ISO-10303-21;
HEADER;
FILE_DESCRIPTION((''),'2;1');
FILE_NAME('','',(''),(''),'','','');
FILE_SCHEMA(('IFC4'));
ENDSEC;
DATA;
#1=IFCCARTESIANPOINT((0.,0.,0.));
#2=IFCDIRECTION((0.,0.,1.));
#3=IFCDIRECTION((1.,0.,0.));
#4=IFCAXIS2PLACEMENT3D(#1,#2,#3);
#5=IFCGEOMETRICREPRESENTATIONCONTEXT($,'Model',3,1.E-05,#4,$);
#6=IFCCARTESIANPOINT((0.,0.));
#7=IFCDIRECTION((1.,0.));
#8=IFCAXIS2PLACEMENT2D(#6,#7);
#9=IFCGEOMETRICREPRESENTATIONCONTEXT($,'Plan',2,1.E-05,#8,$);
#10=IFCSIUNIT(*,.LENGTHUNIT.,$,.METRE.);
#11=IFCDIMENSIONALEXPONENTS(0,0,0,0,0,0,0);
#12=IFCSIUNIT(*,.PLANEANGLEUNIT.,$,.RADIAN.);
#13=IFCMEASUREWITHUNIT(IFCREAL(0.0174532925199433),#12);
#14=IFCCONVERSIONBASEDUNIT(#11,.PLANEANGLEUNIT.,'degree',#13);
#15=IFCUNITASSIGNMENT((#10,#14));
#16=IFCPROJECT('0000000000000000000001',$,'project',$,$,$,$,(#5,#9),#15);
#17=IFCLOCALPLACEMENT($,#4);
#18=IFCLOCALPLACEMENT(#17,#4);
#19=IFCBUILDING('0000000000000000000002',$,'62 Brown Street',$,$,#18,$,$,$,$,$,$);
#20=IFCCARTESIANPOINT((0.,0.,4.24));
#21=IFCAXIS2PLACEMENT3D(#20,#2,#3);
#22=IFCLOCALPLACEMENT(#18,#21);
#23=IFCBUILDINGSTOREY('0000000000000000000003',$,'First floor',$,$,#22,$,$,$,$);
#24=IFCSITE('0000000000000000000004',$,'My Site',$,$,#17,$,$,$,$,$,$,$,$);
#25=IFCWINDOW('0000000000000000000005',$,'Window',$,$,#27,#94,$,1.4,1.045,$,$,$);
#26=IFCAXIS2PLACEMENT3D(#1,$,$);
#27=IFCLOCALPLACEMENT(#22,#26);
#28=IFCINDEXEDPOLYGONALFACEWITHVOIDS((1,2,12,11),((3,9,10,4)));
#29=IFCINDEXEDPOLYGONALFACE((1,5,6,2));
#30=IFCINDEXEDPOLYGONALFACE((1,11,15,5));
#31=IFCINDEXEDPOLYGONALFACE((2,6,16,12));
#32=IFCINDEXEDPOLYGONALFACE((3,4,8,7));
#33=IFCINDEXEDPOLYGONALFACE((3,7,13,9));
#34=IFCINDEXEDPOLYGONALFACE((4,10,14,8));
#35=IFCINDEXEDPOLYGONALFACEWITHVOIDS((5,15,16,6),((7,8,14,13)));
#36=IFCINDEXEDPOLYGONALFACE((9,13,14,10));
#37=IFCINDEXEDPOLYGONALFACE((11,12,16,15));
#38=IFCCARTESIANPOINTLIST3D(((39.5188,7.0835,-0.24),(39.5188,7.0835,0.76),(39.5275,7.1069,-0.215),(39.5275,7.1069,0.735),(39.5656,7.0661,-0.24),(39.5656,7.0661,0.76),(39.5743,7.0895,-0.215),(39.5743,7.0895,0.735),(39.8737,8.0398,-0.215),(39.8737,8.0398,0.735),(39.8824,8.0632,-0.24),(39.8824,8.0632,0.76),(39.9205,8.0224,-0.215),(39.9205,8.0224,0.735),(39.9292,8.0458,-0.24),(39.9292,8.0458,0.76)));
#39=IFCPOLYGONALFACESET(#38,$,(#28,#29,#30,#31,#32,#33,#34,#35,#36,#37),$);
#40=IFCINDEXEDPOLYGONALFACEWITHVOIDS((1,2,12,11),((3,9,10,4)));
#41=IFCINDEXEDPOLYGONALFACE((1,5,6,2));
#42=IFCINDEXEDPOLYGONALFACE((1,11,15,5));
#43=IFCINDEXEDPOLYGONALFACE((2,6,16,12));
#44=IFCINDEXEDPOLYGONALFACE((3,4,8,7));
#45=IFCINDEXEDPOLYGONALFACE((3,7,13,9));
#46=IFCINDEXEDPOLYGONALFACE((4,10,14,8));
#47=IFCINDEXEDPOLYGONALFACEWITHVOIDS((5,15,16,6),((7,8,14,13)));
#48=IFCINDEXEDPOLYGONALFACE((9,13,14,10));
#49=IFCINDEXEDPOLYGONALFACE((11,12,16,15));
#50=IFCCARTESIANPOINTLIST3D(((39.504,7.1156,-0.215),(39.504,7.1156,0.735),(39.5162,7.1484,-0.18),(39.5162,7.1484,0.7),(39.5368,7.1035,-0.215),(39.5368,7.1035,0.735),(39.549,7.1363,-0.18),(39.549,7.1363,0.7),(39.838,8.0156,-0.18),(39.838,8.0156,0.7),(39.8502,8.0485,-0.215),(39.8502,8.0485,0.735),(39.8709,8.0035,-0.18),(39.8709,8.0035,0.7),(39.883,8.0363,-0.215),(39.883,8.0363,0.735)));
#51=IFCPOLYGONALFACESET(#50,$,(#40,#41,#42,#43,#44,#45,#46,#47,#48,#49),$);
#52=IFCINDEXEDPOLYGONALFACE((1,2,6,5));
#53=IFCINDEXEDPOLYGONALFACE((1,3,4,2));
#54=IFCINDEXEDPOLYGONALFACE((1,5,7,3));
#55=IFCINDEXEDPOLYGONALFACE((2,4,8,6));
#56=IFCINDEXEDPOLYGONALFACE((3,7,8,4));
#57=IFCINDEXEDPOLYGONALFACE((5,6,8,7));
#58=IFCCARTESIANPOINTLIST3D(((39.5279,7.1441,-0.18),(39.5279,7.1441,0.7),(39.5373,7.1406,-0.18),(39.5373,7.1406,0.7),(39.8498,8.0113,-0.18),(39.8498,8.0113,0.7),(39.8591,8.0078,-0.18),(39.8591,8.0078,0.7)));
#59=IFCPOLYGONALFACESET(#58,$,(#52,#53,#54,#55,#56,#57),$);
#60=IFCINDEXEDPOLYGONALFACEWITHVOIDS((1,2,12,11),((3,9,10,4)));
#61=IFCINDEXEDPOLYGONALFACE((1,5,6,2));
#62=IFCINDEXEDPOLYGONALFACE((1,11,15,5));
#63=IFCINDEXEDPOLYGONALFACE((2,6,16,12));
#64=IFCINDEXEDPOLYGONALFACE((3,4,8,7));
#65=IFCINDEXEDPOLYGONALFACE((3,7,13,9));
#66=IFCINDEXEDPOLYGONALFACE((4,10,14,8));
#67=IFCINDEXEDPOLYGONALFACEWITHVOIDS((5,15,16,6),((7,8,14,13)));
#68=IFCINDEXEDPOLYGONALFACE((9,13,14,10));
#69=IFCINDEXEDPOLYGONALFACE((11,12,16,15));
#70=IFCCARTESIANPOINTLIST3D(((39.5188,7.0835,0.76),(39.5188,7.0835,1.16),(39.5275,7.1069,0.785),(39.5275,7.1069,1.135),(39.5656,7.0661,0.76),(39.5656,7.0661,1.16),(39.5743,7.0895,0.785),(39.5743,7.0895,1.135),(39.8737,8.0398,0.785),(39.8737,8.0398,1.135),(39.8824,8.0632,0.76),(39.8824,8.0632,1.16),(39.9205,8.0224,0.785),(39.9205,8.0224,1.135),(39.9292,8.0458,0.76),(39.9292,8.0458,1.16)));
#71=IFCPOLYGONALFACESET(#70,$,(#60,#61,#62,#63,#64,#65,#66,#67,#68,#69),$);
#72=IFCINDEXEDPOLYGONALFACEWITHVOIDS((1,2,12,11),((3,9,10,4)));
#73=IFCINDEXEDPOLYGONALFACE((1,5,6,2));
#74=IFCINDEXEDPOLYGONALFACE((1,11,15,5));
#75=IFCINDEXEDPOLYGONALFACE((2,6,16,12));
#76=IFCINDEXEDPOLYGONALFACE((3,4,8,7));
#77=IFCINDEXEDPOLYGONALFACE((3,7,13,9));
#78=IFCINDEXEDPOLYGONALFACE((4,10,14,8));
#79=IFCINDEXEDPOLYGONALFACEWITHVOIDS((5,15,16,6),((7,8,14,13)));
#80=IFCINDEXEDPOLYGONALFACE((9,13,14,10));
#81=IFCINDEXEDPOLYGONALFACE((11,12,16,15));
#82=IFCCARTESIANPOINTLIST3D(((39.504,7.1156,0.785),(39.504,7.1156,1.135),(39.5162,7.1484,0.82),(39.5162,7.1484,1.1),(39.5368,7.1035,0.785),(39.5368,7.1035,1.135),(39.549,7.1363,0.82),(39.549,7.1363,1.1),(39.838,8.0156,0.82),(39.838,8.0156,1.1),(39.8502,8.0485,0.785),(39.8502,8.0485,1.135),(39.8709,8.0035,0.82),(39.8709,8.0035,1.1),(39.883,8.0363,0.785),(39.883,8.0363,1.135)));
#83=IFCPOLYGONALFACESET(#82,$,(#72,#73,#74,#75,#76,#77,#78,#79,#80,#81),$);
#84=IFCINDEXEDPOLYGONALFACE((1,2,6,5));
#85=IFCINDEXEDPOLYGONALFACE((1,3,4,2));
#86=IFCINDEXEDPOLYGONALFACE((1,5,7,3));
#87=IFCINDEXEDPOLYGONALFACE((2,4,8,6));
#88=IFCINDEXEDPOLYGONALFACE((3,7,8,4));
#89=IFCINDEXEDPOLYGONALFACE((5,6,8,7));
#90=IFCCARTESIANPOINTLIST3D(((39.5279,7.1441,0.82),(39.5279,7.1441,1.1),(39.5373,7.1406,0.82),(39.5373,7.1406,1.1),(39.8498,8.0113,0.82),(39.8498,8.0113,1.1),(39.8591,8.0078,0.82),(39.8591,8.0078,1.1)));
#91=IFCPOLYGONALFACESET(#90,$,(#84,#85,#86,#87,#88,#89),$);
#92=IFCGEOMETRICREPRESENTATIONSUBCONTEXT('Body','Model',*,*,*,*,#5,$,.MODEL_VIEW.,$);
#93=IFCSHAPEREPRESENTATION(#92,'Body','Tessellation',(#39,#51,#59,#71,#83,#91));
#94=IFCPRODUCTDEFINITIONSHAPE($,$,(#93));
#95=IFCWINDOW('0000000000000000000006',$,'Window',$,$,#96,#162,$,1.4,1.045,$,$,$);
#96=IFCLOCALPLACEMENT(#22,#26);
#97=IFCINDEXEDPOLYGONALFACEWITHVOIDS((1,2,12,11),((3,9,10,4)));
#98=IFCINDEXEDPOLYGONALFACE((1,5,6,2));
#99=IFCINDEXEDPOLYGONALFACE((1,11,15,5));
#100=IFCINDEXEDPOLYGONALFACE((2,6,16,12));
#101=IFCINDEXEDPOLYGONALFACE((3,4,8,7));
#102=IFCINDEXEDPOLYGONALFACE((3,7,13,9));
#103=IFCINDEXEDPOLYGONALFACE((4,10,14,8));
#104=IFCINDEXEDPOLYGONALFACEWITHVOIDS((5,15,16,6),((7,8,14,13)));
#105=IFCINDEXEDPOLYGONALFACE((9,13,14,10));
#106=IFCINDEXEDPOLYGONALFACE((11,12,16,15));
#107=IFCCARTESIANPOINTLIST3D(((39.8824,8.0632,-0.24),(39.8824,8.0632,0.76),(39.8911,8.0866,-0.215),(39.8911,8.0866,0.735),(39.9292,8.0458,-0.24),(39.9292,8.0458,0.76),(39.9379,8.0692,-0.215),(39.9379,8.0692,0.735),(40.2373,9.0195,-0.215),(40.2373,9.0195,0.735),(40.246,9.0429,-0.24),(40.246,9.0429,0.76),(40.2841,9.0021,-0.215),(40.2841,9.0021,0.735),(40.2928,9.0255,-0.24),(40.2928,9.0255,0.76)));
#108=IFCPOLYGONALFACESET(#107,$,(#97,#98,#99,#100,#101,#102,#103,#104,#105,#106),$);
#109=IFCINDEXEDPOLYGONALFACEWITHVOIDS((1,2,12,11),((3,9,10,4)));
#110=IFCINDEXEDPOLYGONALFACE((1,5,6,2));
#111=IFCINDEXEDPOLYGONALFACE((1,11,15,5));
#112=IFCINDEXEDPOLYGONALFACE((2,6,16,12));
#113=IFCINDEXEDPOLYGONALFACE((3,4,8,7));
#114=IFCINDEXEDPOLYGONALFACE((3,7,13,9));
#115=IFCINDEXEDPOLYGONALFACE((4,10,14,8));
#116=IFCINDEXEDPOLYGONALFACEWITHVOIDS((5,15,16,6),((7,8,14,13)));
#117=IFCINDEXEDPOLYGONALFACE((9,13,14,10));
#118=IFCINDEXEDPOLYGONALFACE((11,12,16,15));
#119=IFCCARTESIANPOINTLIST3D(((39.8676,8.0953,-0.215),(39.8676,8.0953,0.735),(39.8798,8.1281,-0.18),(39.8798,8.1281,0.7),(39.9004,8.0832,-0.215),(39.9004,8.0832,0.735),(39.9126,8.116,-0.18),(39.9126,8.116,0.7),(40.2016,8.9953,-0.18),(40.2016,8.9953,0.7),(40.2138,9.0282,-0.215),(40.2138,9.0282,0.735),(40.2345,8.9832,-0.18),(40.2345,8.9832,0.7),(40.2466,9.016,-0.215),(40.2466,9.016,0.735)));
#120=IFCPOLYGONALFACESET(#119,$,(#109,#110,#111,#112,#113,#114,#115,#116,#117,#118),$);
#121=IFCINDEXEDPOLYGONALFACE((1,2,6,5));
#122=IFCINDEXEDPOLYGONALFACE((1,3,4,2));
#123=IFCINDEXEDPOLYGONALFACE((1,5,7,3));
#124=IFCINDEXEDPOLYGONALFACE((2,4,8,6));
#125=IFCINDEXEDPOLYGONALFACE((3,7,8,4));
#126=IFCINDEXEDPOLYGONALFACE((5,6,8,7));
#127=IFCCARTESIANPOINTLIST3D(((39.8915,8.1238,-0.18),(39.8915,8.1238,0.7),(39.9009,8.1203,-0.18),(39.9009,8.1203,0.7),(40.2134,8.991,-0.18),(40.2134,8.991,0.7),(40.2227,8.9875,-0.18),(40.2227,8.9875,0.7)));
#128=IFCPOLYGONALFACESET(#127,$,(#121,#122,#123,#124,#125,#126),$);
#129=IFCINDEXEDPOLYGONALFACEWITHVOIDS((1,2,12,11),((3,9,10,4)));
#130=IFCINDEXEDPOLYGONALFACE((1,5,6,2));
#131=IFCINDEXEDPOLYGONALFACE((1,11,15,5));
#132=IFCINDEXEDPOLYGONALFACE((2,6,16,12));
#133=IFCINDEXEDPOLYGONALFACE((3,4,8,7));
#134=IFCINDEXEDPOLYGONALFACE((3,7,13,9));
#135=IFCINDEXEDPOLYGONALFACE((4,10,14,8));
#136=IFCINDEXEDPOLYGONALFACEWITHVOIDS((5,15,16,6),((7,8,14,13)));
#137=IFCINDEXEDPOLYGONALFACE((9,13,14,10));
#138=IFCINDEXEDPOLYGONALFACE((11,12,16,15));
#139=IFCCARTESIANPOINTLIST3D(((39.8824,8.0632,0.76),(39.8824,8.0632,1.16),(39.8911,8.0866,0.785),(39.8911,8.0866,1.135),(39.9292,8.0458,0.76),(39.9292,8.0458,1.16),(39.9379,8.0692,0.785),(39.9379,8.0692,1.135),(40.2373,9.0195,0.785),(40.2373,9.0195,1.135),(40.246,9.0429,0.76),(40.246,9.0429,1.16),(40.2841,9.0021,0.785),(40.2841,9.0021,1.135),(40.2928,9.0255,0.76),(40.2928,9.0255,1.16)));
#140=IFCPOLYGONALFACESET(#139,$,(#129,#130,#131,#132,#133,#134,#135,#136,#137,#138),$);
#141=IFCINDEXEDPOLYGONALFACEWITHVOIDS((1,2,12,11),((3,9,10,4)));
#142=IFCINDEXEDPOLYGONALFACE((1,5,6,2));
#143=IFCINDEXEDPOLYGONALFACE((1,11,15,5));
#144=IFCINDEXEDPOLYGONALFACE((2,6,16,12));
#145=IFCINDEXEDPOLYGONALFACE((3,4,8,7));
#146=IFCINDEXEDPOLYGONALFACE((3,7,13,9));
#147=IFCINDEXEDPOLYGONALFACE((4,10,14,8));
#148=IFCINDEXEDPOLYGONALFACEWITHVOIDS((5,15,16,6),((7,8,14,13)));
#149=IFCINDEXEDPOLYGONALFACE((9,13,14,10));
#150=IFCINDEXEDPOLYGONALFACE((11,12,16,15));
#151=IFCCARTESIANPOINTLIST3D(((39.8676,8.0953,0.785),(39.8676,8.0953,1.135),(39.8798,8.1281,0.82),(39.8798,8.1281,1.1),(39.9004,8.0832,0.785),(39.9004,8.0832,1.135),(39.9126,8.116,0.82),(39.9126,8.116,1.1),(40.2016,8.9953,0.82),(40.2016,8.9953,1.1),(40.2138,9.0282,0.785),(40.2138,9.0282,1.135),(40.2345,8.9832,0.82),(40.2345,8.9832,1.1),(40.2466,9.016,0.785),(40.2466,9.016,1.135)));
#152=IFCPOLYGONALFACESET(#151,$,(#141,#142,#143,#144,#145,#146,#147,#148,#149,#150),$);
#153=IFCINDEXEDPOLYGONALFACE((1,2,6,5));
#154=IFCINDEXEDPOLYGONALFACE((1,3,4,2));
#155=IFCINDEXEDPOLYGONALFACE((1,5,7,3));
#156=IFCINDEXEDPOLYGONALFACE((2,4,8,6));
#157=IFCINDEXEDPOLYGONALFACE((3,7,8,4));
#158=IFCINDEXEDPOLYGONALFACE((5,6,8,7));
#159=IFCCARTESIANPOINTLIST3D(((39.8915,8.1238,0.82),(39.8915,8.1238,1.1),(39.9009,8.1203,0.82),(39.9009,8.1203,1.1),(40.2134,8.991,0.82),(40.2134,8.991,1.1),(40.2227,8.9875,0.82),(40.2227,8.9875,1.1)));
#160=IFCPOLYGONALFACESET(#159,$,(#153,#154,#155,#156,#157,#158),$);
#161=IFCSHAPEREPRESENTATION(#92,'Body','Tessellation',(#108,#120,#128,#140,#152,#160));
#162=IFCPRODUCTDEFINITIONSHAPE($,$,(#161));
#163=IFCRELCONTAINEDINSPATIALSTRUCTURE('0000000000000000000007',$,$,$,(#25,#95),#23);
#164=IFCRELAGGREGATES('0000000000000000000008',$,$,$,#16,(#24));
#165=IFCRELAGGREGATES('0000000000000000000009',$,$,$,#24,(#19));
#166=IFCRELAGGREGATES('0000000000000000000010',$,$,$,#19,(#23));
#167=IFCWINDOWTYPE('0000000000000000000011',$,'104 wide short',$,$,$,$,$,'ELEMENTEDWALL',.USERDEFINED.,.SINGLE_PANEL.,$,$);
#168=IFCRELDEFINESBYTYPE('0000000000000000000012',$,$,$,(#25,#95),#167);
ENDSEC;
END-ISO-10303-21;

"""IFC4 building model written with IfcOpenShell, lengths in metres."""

from ifc_helpers import new_model, entity, si_unit, converted_unit, frame, origin_with_axes, origin_2d_with_axis, place, context, subcontext, project, spatial, line, indexed_curve, outline, extrude, shape, source, transform, mapped, type_object, type_shapes, element, save


model = new_model("IFC4")

# Units and contexts
model_context = context("Model", 3, precision=1e-05, world=origin_with_axes())
plan_context = context("Plan", 2, precision=1e-05, world=origin_2d_with_axis())
body_context_1 = subcontext(model_context, "Body", "Model", "MODEL_VIEW")
body_context_2 = subcontext(plan_context, "Body", "Plan", "PLAN_VIEW")
ifc_project = project(units=[si_unit("LENGTHUNIT", "METRE"), converted_unit("PLANEANGLEUNIT", "degree", entity("IfcReal", 0.0174532925199433), si_unit("PLANEANGLEUNIT", "RADIAN"), dimensions=[0, 0, 0, 0, 0, 0, 0])], contexts=[model_context, plan_context])

# Site, building, storey
site_placement = place(None, origin_with_axes())
site = spatial("IfcSite", under=ifc_project, at=site_placement, Name="My Site")
building_placement = place(site_placement, origin_with_axes())
building = spatial("IfcBuilding", under=site, at=building_placement, Name="62 Brown Street")
storey_placement = place(building_placement, frame((0.0, 0.0, 4.24), z_axis=(0.0, 0.0, 1.0), x_axis=(1.0, 0.0, 0.0)))
storey = spatial("IfcBuildingStorey", under=building, at=storey_placement, Name="First floor")

# Shared definitions
window_type = type_object("IfcWindowType", Name="104 wide short", ElementType="ELEMENTEDWALL", PartitioningType="SINGLE_PANEL", PredefinedType="USERDEFINED")
shared_shape_1 = source(origin_with_axes(), body_context_1, "Body", "SweptSolid", [
    extrude(outline(indexed_curve([(0.0, 0.0), (1.045, 0.0), (1.045, 1.0), (0.0, 1.0)], segments=[line(1, 2, 3, 4, 1)]), holes=[indexed_curve([(0.025, 0.025), (1.02, 0.025), (1.02, 0.975), (0.025, 0.975)], segments=[line(1, 2, 3, 4, 1)])]), frame((0.0, 0.15, 0.0), z_axis=(0.0, -1.0, 0.0), x_axis=(1.0, 0.0, 0.0)), (0.0, 0.0, -1.0), 0.05),
    extrude(outline(indexed_curve([(0.0, 0.0), (0.995, 0.0), (0.995, 0.95), (0.0, 0.95)], segments=[line(1, 2, 3, 4, 1)]), holes=[indexed_curve([(0.035, 0.035), (0.96, 0.035), (0.96, 0.915), (0.035, 0.915)], segments=[line(1, 2, 3, 4, 1)])]), frame((0.025, 0.19, 0.025), z_axis=(0.0, -1.0, 0.0), x_axis=(1.0, 0.0, 0.0)), (0.0, 0.0, -1.0), 0.035),
    extrude(outline(indexed_curve([(0.035, 0.035), (0.96, 0.035), (0.96, 0.915), (0.035, 0.915)], segments=[line(1, 2, 3, 4, 1)])), frame((0.025, 0.2025, 0.025), z_axis=(0.0, -1.0, 0.0), x_axis=(1.0, 0.0, 0.0)), (0.0, 0.0, -1.0), 0.01),
    extrude(outline(indexed_curve([(0.0, 0.0), (1.045, 0.0), (1.045, 0.4), (0.0, 0.4)], segments=[line(1, 2, 3, 4, 1)]), holes=[indexed_curve([(0.025, 0.025), (1.02, 0.025), (1.02, 0.375), (0.025, 0.375)], segments=[line(1, 2, 3, 4, 1)])]), frame((0.0, 0.15, 1.0), z_axis=(0.0, -1.0, 0.0), x_axis=(1.0, 0.0, 0.0)), (0.0, 0.0, -1.0), 0.05),
    extrude(outline(indexed_curve([(0.0, 0.0), (0.995, 0.0), (0.995, 0.35), (0.0, 0.35)], segments=[line(1, 2, 3, 4, 1)]), holes=[indexed_curve([(0.035, 0.035), (0.96, 0.035), (0.96, 0.315), (0.035, 0.315)], segments=[line(1, 2, 3, 4, 1)])]), frame((0.025, 0.19, 1.025), z_axis=(0.0, -1.0, 0.0), x_axis=(1.0, 0.0, 0.0)), (0.0, 0.0, -1.0), 0.035),
    extrude(outline(indexed_curve([(0.035, 0.035), (0.96, 0.035), (0.96, 0.315), (0.035, 0.315)], segments=[line(1, 2, 3, 4, 1)])), frame((0.025, 0.2025, 1.025), z_axis=(0.0, -1.0, 0.0), x_axis=(1.0, 0.0, 0.0)), (0.0, 0.0, -1.0), 0.01),
])
shared_shape_2 = source(origin_with_axes(), body_context_2, "Body", "Curve2D", [
    entity("IfcIndexedPolyCurve", entity("IfcCartesianPointList2D", [[0.025, 0.15], [1.02, 0.15]])),
    entity("IfcIndexedPolyCurve", entity("IfcCartesianPointList2D", [[0.0, 0.2], [0.025, 0.2], [0.025, 0.15], [0.0, 0.15]]), [entity("IfcLineIndex", [1, 2, 3, 4, 1])]),
    entity("IfcIndexedPolyCurve", entity("IfcCartesianPointList2D", [[1.045, 0.2], [1.02, 0.2], [1.02, 0.15], [1.045, 0.15]]), [entity("IfcLineIndex", [1, 2, 3, 4, 1])]),
    entity("IfcIndexedPolyCurve", entity("IfcCartesianPointList2D", [[0.025, 0.19], [0.06, 0.19], [0.06, 0.225], [0.025, 0.225]]), [entity("IfcLineIndex", [1, 2, 3, 4, 1])]),
    entity("IfcIndexedPolyCurve", entity("IfcCartesianPointList2D", [[1.02, 0.19], [0.985, 0.19], [0.985, 0.225], [1.02, 0.225]]), [entity("IfcLineIndex", [1, 2, 3, 4, 1])]),
    entity("IfcIndexedPolyCurve", entity("IfcCartesianPointList2D", [[0.06, 0.19], [0.985, 0.19]])),
    entity("IfcIndexedPolyCurve", entity("IfcCartesianPointList2D", [[0.06, 0.225], [0.985, 0.225]])),
    entity("IfcIndexedPolyCurve", entity("IfcCartesianPointList2D", [[0.06, 0.2075], [0.985, 0.2075]])),
])
type_shapes(window_type, [shared_shape_1, shared_shape_2])

# Windows
for number, where, z_axis, x_axis, name in (
    (1, (39.7063, 7.0139, -0.24), (0.0, 0.0, 1.0), (0.347944, 0.937515, 0.0), "Window"),
    (2, (40.0699, 7.9936, -0.24), (0.0, 0.0, 1.0), (0.347944, 0.937515, 0.0), "Window"),
):
    element("IfcWindow", number, at=place(storey_placement, frame(where, z_axis=z_axis, x_axis=x_axis)), inside=storey, type_object=window_type, Name=name, OverallHeight=1.4, OverallWidth=1.045, shapes=[
        shape(body_context_1, "Body", "MappedRepresentation", [mapped(shared_shape_1, transform((0.0, 0.0, 0.0), x_axis=(1.0, 0.0, 0.0), y_axis=(0.0, 1.0, 0.0), z_axis=(0.0, 0.0, 1.0), scale=1.0))]),
        shape(body_context_2, "Body", "MappedRepresentation", [mapped(shared_shape_2, transform((0.0, 0.0, 0.0), x_axis=(1.0, 0.0, 0.0), y_axis=(0.0, 1.0, 0.0), z_axis=(0.0, 0.0, 1.0), scale=1.0))]),
    ])

save(model, "model.ifc")
